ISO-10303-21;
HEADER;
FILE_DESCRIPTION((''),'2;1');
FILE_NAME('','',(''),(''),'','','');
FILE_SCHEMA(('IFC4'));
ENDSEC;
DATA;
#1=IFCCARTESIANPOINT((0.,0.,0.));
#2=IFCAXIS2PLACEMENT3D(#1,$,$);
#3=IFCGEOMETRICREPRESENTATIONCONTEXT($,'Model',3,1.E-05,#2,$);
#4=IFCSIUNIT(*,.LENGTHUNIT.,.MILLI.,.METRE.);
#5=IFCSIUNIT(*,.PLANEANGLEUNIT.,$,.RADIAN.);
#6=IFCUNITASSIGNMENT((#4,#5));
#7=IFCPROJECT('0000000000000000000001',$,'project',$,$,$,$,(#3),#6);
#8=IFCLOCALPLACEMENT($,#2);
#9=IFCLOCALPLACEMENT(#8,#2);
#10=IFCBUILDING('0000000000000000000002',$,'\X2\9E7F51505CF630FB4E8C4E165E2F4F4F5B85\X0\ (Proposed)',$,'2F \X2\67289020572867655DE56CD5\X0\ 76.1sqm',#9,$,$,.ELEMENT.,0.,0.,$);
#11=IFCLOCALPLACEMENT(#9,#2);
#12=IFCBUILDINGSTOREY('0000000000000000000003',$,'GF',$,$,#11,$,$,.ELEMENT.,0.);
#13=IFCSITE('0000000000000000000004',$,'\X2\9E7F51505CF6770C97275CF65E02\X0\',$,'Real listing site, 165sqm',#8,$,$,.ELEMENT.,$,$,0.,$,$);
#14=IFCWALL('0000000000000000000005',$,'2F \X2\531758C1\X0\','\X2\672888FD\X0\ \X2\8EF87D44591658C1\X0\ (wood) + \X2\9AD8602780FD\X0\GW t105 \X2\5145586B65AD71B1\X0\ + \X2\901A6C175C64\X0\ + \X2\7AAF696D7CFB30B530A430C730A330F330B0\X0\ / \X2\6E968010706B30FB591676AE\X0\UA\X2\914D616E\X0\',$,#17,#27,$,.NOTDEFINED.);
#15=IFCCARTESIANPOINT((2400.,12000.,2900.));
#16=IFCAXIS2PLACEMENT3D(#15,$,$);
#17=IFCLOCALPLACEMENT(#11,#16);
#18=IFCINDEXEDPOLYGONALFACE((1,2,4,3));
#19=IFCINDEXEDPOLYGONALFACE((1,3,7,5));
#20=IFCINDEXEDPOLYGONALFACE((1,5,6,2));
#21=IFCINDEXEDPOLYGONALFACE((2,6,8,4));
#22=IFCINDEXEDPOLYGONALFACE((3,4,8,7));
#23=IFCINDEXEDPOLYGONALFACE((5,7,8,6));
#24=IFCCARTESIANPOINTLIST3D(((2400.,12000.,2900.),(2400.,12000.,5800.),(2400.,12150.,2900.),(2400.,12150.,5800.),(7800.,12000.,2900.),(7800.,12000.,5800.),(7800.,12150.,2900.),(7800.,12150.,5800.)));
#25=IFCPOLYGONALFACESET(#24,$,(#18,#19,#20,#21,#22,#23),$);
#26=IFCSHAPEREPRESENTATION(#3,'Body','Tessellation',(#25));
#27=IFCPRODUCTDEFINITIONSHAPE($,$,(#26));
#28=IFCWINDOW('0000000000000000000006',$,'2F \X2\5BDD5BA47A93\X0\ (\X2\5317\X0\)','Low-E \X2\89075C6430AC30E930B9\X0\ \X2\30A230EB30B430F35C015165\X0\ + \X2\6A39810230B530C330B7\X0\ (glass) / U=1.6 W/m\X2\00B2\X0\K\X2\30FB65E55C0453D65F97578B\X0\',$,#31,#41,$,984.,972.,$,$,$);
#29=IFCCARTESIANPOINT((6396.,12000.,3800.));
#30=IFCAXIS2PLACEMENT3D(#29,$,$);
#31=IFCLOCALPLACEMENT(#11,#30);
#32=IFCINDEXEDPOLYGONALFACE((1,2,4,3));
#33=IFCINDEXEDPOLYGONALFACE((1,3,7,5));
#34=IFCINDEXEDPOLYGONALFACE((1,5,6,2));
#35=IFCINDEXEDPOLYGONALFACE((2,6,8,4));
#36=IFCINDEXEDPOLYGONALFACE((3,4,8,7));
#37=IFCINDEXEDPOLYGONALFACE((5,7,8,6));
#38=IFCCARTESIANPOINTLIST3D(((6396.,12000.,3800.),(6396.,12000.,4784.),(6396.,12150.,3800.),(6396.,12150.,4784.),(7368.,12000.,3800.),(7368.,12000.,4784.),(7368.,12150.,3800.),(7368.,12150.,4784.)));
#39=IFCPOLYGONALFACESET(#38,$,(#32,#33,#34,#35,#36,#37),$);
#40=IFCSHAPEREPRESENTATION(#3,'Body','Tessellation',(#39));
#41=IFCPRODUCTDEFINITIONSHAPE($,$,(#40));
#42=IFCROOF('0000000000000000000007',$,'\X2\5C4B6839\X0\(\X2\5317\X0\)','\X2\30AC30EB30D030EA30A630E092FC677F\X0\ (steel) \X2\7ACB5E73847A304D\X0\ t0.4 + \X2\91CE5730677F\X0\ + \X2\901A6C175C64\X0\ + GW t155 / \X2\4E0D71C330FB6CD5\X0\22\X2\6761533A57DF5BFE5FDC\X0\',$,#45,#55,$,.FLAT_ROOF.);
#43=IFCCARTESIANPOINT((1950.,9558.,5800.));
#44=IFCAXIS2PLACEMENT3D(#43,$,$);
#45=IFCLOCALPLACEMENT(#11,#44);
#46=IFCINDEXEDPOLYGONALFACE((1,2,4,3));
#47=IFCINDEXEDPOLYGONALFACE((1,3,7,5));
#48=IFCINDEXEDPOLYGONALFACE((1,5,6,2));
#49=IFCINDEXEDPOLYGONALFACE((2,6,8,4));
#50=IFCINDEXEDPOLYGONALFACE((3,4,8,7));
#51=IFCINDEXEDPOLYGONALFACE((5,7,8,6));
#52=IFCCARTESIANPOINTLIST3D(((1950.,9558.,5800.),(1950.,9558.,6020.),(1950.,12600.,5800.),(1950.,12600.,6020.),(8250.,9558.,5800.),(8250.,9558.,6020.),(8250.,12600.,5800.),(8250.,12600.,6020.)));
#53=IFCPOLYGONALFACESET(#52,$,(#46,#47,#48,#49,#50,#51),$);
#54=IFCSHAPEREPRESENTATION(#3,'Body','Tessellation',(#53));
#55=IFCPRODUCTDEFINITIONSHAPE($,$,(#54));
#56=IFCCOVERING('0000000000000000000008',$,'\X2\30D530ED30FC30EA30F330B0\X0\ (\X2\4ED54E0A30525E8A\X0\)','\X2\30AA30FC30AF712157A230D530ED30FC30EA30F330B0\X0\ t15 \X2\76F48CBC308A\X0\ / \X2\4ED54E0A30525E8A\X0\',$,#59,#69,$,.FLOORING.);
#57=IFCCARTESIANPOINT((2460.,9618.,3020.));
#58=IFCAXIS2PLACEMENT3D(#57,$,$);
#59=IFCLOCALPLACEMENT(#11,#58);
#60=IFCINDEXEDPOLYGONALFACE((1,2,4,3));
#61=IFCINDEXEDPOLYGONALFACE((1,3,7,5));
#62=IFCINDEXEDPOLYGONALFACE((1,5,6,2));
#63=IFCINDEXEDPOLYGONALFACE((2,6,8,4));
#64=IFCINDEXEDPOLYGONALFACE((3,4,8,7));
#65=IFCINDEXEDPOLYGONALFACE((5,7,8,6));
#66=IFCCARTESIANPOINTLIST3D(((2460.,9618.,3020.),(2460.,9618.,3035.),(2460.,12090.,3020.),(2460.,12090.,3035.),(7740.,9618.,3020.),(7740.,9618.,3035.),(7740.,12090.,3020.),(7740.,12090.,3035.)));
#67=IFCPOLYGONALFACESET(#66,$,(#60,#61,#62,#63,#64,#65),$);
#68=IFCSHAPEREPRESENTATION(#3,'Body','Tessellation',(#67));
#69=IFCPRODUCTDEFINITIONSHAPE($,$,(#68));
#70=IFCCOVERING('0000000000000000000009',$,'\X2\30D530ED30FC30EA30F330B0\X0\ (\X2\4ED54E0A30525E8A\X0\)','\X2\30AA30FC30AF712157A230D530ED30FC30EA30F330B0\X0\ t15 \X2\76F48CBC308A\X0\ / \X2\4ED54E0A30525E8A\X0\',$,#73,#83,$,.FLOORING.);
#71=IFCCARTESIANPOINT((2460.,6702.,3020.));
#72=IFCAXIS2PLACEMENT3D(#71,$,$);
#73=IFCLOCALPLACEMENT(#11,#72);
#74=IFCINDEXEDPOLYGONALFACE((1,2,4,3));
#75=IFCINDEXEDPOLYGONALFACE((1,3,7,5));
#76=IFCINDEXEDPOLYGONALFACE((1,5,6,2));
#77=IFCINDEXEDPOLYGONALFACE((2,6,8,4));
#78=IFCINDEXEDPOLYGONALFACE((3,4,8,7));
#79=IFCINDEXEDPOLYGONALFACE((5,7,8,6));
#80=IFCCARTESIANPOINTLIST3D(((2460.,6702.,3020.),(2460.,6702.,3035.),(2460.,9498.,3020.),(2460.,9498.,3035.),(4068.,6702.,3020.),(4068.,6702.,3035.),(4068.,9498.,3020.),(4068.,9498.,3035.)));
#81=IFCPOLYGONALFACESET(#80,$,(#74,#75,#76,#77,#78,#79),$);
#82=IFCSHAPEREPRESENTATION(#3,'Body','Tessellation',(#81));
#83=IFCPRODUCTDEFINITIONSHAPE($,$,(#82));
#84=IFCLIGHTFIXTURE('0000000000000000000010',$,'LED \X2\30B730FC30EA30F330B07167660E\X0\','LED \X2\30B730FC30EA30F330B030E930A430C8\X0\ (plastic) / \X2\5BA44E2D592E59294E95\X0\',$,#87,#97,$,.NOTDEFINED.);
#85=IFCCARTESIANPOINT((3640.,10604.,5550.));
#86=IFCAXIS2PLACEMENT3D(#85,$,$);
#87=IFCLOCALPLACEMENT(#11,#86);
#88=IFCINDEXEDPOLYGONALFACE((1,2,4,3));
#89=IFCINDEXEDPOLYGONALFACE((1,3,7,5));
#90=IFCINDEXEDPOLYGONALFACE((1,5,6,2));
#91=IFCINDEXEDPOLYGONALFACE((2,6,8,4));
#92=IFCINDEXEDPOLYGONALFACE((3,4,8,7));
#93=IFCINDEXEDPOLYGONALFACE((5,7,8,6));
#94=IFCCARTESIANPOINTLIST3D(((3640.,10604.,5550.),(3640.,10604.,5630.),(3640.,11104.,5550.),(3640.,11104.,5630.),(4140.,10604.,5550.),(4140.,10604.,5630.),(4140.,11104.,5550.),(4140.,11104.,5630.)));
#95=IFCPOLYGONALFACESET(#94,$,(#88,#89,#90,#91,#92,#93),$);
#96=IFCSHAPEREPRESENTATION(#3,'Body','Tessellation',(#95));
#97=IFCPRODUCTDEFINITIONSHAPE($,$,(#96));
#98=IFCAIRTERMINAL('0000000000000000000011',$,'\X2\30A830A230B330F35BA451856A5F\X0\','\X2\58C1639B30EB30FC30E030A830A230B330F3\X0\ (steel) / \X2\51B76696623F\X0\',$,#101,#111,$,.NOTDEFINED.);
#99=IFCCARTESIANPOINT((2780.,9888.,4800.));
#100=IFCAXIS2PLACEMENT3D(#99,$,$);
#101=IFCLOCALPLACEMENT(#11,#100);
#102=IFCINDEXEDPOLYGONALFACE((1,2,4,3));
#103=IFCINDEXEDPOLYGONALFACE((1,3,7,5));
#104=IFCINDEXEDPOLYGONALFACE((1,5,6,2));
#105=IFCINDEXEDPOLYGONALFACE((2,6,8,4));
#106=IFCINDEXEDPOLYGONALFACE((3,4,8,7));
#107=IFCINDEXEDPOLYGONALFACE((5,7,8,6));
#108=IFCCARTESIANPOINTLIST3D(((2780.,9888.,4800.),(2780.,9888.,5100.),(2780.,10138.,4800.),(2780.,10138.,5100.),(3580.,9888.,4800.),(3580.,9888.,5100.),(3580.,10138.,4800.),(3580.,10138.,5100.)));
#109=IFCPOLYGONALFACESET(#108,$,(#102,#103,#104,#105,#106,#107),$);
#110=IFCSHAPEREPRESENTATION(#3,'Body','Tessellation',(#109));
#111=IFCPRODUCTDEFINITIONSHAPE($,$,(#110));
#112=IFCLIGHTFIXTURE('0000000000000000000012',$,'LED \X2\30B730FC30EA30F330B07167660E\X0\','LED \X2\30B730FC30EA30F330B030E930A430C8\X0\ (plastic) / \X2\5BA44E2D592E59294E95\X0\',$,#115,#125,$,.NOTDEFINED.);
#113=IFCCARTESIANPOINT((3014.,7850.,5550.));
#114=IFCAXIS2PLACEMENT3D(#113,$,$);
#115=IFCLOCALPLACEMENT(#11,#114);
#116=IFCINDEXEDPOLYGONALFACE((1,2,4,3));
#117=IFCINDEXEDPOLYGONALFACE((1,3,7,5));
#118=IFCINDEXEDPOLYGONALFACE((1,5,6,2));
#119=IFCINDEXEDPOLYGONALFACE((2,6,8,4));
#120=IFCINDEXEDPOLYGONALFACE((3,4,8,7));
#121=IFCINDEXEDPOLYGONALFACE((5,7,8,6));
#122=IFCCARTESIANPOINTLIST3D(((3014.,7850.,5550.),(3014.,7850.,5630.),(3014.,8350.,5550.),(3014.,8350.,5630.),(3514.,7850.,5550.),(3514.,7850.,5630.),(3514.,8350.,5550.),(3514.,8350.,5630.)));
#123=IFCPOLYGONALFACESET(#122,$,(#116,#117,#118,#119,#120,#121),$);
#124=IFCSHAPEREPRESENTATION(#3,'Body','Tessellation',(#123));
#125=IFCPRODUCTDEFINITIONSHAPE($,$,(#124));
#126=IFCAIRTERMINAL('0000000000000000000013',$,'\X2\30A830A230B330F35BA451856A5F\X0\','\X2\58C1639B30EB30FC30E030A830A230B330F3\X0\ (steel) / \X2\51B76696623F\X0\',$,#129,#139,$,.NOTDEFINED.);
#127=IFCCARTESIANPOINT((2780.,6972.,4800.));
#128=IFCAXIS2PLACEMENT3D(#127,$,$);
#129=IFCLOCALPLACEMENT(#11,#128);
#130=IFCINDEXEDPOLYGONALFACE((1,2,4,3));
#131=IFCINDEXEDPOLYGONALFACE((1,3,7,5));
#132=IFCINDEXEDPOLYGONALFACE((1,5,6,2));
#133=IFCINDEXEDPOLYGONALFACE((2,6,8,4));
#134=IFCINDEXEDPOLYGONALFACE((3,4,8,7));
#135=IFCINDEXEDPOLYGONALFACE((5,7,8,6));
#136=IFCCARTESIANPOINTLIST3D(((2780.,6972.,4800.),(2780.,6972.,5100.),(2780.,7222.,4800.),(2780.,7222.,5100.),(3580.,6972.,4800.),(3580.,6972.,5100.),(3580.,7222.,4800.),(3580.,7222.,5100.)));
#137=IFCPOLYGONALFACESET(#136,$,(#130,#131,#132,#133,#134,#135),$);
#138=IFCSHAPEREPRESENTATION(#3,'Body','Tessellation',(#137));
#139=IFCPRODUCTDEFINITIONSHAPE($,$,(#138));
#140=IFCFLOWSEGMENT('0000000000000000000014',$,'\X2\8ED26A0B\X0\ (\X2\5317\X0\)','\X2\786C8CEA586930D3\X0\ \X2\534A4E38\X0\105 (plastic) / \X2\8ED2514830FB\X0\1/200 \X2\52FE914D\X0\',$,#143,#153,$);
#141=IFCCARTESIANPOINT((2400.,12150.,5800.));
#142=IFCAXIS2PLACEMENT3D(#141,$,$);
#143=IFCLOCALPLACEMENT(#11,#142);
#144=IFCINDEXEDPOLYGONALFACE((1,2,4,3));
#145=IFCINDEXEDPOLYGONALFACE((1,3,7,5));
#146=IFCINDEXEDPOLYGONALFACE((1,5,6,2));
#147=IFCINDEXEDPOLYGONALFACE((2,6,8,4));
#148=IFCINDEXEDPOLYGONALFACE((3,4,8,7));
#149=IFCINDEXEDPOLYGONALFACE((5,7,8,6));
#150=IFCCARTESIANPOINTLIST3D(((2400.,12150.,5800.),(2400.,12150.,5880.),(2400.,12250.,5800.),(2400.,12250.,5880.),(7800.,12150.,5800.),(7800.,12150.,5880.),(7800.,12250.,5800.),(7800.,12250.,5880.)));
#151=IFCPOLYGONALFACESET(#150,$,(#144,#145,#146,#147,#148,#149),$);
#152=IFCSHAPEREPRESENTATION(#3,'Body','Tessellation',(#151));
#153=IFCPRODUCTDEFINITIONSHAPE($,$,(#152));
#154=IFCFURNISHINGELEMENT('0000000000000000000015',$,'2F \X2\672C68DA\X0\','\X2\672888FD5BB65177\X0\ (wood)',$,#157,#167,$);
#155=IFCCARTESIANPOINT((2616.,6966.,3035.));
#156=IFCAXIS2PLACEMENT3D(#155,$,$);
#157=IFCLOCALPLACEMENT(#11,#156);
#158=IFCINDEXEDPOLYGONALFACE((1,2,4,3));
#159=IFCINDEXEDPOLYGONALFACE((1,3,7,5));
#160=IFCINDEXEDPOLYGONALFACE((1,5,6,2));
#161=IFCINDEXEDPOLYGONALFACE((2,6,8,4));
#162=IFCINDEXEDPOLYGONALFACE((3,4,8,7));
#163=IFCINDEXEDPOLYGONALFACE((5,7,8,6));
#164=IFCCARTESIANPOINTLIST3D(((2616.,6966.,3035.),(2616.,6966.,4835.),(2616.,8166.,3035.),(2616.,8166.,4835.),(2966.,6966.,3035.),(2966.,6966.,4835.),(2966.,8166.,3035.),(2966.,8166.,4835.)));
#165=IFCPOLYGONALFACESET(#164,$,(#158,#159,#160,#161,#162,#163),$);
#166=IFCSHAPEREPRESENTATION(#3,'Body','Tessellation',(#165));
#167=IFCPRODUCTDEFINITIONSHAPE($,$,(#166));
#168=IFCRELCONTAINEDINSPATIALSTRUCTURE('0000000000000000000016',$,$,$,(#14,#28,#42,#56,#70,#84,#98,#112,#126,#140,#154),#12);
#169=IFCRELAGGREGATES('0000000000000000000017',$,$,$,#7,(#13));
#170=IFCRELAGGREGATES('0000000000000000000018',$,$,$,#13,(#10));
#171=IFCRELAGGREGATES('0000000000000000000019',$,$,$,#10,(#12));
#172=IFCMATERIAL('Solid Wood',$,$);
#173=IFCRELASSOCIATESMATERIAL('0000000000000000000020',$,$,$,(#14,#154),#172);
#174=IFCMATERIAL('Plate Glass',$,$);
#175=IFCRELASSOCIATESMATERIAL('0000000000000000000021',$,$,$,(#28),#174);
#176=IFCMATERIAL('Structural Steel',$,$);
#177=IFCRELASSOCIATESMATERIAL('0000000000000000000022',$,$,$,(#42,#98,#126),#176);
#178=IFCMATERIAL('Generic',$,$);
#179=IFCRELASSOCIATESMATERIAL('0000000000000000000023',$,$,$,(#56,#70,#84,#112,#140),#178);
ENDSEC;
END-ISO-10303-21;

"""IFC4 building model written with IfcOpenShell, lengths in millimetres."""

from ifc_helpers import new_model, si_unit, frame, frame_2d, origin, place, context, project, spatial, rectangle, extrude, material, element, fill, save


model = new_model("IFC4")

# Units and contexts
model_context = context("Model", 3, precision=1e-05, world=origin())
ifc_project = project(units=[si_unit("LENGTHUNIT", "METRE", prefix="MILLI"), si_unit("PLANEANGLEUNIT", "RADIAN")], contexts=[model_context])

# Site, building, storey
site_placement = place(None, origin())
site = spatial("IfcSite", under=ifc_project, at=site_placement, Name="鹿児島県霧島市", ObjectType="Real listing site, 165sqm", CompositionType="ELEMENT", RefElevation=0.0)
building_placement = place(site_placement, origin())
building = spatial("IfcBuilding", under=site, at=building_placement, Name="鹿児島・二世帯住宅 (Proposed)", ObjectType="2F 木造在来工法 76.1sqm", CompositionType="ELEMENT", ElevationOfRefHeight=0.0, ElevationOfTerrain=0.0)
storey_placement = place(building_placement, origin())
storey = spatial("IfcBuildingStorey", under=building, at=storey_placement, Name="GF", CompositionType="ELEMENT", Elevation=0.0)

# Shared definitions
ifc_material_1 = material(Name="Solid Wood")

# Wall, opening, window
wall_placement = place(storey_placement, frame((2400.0, 12000.0, 2900.0)))
wall = element("IfcWall", 1, at=wall_placement, inside=storey, material=ifc_material_1, Name="2F 北壁", Description="木製 軸組外壁 (wood) + 高性能GW t105 充填断熱 + 通気層 + 窯業系サイディング / 準耐火・外皮UA配慮", PredefinedType="NOTDEFINED", context=model_context, shape_type="SweptSolid", body=[
    extrude(rectangle(XDim=5400.0, YDim=150.0, at=frame_2d((2700.0, 75.0))), frame((2400.0, 12000.0, 2900.0)), (0.0, 0.0, 1.0), 2900.0),
])
opening_placement = place(storey_placement, frame((6396.0, 12000.0, 3800.0)))
opening = element("IfcOpeningElement", 2, at=opening_placement, cuts=wall, PredefinedType="NOTDEFINED", context=model_context, shape_type="SweptSolid", body=[
    extrude(rectangle(XDim=972.0, YDim=150.0, at=frame_2d((486.0, 75.0))), frame((6396.0, 12000.0, 3800.0)), (0.0, 0.0, 1.0), 984.0),
])
ifc_material_2 = material(Name="Plate Glass")
window_placement = place(storey_placement, frame((6396.0, 12000.0, 3800.0)))
window = element("IfcWindow", 3, at=window_placement, inside=storey, material=ifc_material_2, Name="2F 寝室窓 (北)", Description="Low-E 複層ガラス アルゴン封入 + 樹脂サッシ (glass) / U=1.6 W/m²K・日射取得型", OverallHeight=984.0, OverallWidth=972.0, context=model_context, shape_type="SweptSolid", body=[
    extrude(rectangle(XDim=972.0, YDim=150.0, at=frame_2d((486.0, 75.0))), frame((6396.0, 12000.0, 3800.0)), (0.0, 0.0, 1.0), 984.0),
])
fill(opening, window)

# Roof
ifc_material_3 = material(Name="Structural Steel")
for number, where, name in (
    (4, (1950.0, 9558.0, 5800.0), "屋根(北)"),
):
    element("IfcRoof", number, at=place(storey_placement, frame(where)), inside=storey, material=ifc_material_3, Name=name, Description="ガルバリウム鋼板 (steel) 立平葺き t0.4 + 野地板 + 通気層 + GW t155 / 不燃・法22条区域対応", PredefinedType="FLAT_ROOF", context=model_context, shape_type="SweptSolid", body=[
        extrude(rectangle(XDim=6300.0, YDim=3042.0, at=frame_2d((3150.0, 1521.0))), frame((1950.0, 9558.0, 5800.0)), (0.0, 0.0, 1.0), 220.0),
    ])

# Coverings
ifc_material_4 = material(Name="Generic")
covering_1_placement = place(storey_placement, frame((2460.0, 9618.0, 3020.0)))
element("IfcCovering", 5, at=covering_1_placement, inside=storey, material=ifc_material_4, Name="フローリング (仕上げ床)", Description="オーク無垢フローリング t15 直貼り / 仕上げ床", PredefinedType="FLOORING", context=model_context, shape_type="SweptSolid", body=[
    extrude(rectangle(XDim=5280.0, YDim=2472.0, at=frame_2d((2640.0, 1236.0))), frame((2460.0, 9618.0, 3020.0)), (0.0, 0.0, 1.0), 15.0),
])
covering_2_placement = place(storey_placement, frame((2460.0, 6702.0, 3020.0)))
element("IfcCovering", 6, at=covering_2_placement, inside=storey, material=ifc_material_4, Name="フローリング (仕上げ床)", Description="オーク無垢フローリング t15 直貼り / 仕上げ床", PredefinedType="FLOORING", context=model_context, shape_type="SweptSolid", body=[
    extrude(rectangle(XDim=1608.0, YDim=2796.0, at=frame_2d((804.0, 1398.0))), frame((2460.0, 6702.0, 3020.0)), (0.0, 0.0, 1.0), 15.0),
])

# Light fixture
light_fixture_1_placement = place(storey_placement, frame((3640.0, 10604.0, 5550.0)))
element("IfcLightFixture", 7, at=light_fixture_1_placement, inside=storey, material=ifc_material_4, Name="LED シーリング照明", Description="LED シーリングライト (plastic) / 室中央天井", PredefinedType="NOTDEFINED", context=model_context, shape_type="SweptSolid", body=[
    extrude(rectangle(XDim=500.0, YDim=500.0, at=frame_2d((250.0, 250.0))), frame((3640.0, 10604.0, 5550.0)), (0.0, 0.0, 1.0), 80.0),
])

# Air terminal
air_terminal_1_placement = place(storey_placement, frame((2780.0, 9888.0, 4800.0)))
element("IfcAirTerminal", 8, at=air_terminal_1_placement, inside=storey, material=ifc_material_3, Name="エアコン室内機", Description="壁掛ルームエアコン (steel) / 冷暖房", PredefinedType="NOTDEFINED", context=model_context, shape_type="SweptSolid", body=[
    extrude(rectangle(XDim=800.0, YDim=250.0, at=frame_2d((400.0, 125.0))), frame((2780.0, 9888.0, 4800.0)), (0.0, 0.0, 1.0), 300.0),
])

# Light fixture
light_fixture_2_placement = place(storey_placement, frame((3014.0, 7850.0, 5550.0)))
element("IfcLightFixture", 9, at=light_fixture_2_placement, inside=storey, material=ifc_material_4, Name="LED シーリング照明", Description="LED シーリングライト (plastic) / 室中央天井", PredefinedType="NOTDEFINED", context=model_context, shape_type="SweptSolid", body=[
    extrude(rectangle(XDim=500.0, YDim=500.0, at=frame_2d((250.0, 250.0))), frame((3014.0, 7850.0, 5550.0)), (0.0, 0.0, 1.0), 80.0),
])

# Air terminal
air_terminal_2_placement = place(storey_placement, frame((2780.0, 6972.0, 4800.0)))
element("IfcAirTerminal", 10, at=air_terminal_2_placement, inside=storey, material=ifc_material_3, Name="エアコン室内機", Description="壁掛ルームエアコン (steel) / 冷暖房", PredefinedType="NOTDEFINED", context=model_context, shape_type="SweptSolid", body=[
    extrude(rectangle(XDim=800.0, YDim=250.0, at=frame_2d((400.0, 125.0))), frame((2780.0, 6972.0, 4800.0)), (0.0, 0.0, 1.0), 300.0),
])

# Flow segment
flow_segment_placement = place(storey_placement, frame((2400.0, 12150.0, 5800.0)))
element("IfcFlowSegment", 11, at=flow_segment_placement, inside=storey, material=ifc_material_4, Name="軒樋 (北)", Description="硬質塩ビ 半丸105 (plastic) / 軒先・1/200 勾配", context=model_context, shape_type="SweptSolid", body=[
    extrude(rectangle(XDim=5400.0, YDim=100.0, at=frame_2d((2700.0, 50.0))), frame((2400.0, 12150.0, 5800.0)), (0.0, 0.0, 1.0), 80.0),
])

# Furnishing element
furnishing_placement = place(storey_placement, frame((2616.0, 6966.0, 3035.0)))
element("IfcFurnishingElement", 12, at=furnishing_placement, inside=storey, material=ifc_material_1, Name="2F 本棚", Description="木製家具 (wood)", context=model_context, shape_type="SweptSolid", body=[
    extrude(rectangle(XDim=350.0, YDim=1200.0, at=frame_2d((175.0, 600.0))), frame((2616.0, 6966.0, 3035.0)), (0.0, 0.0, 1.0), 1800.0),
])

save(model, "model.ifc")
